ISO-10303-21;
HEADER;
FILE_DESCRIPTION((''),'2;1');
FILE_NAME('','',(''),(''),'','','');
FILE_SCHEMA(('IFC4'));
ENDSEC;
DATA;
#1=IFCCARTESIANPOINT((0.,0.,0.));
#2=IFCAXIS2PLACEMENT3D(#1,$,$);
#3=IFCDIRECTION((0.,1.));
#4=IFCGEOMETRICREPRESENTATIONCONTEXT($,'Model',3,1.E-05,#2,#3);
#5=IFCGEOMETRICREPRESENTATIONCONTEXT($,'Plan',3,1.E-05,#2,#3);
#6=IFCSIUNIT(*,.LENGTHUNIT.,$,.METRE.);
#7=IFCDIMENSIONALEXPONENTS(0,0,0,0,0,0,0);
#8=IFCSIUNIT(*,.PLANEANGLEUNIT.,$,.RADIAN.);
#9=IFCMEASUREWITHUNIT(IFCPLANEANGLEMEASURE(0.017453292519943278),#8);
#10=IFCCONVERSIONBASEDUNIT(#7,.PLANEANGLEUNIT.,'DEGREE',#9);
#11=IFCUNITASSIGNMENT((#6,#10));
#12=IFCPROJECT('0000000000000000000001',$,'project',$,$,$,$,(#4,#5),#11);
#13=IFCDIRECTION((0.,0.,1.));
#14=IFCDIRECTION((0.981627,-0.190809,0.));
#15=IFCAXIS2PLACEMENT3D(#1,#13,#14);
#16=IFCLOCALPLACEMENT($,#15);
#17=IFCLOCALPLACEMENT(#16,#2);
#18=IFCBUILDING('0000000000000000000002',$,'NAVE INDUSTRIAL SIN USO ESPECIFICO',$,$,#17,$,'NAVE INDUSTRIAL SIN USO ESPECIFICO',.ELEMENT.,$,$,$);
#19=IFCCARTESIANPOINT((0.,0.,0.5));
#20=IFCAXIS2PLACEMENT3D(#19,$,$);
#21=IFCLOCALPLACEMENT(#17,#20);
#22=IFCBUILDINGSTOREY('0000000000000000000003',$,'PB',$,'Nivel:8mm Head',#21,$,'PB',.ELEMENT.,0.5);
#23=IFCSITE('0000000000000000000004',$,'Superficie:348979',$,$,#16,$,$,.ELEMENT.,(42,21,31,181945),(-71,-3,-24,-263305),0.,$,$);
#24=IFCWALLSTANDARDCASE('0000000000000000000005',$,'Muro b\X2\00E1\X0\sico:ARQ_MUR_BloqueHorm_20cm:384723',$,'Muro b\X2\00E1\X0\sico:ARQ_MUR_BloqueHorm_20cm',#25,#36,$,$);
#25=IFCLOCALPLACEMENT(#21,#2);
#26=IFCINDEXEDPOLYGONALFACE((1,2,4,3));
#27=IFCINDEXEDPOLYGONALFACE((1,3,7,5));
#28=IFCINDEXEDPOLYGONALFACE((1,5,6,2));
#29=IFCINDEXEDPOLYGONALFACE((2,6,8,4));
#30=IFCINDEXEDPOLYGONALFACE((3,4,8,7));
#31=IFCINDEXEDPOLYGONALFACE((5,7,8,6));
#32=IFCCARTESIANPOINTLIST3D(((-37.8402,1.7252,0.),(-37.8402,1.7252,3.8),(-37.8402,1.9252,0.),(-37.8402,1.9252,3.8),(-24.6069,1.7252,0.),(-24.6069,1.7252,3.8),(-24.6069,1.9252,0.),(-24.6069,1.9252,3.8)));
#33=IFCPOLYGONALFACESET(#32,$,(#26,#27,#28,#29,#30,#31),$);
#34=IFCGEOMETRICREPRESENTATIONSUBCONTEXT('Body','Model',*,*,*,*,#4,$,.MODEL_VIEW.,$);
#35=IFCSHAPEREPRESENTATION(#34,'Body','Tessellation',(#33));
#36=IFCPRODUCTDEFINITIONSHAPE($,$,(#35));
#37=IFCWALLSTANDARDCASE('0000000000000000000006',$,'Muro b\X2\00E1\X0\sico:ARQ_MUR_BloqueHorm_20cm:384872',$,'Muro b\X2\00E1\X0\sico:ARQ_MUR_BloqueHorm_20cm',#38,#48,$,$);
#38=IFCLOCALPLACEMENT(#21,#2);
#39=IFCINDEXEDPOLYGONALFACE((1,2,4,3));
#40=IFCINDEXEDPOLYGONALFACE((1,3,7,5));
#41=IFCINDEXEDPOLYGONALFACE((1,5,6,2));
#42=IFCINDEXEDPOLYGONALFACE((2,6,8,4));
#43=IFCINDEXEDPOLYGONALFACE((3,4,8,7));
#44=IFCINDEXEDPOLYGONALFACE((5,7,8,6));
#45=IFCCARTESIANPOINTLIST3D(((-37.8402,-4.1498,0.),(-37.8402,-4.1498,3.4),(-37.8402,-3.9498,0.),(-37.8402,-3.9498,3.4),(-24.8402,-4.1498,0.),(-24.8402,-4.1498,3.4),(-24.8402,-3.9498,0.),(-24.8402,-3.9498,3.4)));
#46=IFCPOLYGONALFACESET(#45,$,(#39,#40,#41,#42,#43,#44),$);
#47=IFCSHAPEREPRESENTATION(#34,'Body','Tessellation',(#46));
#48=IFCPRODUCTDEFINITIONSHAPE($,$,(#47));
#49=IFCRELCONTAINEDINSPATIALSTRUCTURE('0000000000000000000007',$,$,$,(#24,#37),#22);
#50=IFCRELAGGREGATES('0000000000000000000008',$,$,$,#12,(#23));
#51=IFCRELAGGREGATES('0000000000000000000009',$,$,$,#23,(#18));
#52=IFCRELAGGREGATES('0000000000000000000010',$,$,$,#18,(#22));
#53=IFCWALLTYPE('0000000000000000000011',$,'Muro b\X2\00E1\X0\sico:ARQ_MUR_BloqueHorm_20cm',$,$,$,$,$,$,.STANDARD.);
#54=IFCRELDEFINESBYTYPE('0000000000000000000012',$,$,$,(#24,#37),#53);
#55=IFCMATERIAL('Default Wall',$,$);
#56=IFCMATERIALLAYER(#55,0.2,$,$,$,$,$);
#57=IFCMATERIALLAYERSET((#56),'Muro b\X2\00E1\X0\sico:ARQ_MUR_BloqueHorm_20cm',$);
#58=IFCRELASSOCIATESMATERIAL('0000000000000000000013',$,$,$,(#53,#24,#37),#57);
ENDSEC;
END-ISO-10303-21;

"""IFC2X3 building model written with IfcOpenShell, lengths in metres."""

from ifc_helpers import new_model, entity, si_unit, converted_unit, direction, frame, frame_2d, origin, place, context, subcontext, project, spatial, polyline, rectangle, extrude, clip, bounded_halfspace, material, layer, layer_set, layer_usage, type_object, element, save


model = new_model("IFC2X3")

# Units and contexts
model_context = context("Model", 3, precision=1e-05, world=origin(), true_north=direction((0.0, 1.0)))
plan_context = context("Plan", 3, precision=1e-05, world=origin(), true_north=direction((0.0, 1.0)))
body_context = subcontext(model_context, "Body", "Model", "MODEL_VIEW")
ifc_project = project(units=[si_unit("LENGTHUNIT", "METRE"), converted_unit("PLANEANGLEUNIT", "DEGREE", entity("IfcPlaneAngleMeasure", 0.017453292519943278), si_unit("PLANEANGLEUNIT", "RADIAN"), dimensions=[0, 0, 0, 0, 0, 0, 0])], contexts=[model_context, plan_context])

# Site, building, storey
site_placement = place(None, frame((0.0, 0.0, 0.0), z_axis=(0.0, 0.0, 1.0), x_axis=(0.981627, -0.190809, 0.0)))
site = spatial("IfcSite", under=ifc_project, at=site_placement, Name="Superficie:348979", CompositionType="ELEMENT", RefLatitude=(42, 21, 31, 181945), RefLongitude=(-71, -3, -24, -263305), RefElevation=0.0)
building_placement = place(site_placement, origin())
building = spatial("IfcBuilding", under=site, at=building_placement, Name="NAVE INDUSTRIAL SIN USO ESPECIFICO", LongName="NAVE INDUSTRIAL SIN USO ESPECIFICO", CompositionType="ELEMENT")
storey_placement = place(building_placement, frame((0.0, 0.0, 0.5)))
storey = spatial("IfcBuildingStorey", under=building, at=storey_placement, Name="PB", ObjectType="Nivel:8mm Head", LongName="PB", CompositionType="ELEMENT", Elevation=0.5)

# Shared definitions
ifc_material_1 = material(Name="Default Wall")
ifc_layer_1 = layer(ifc_material_1, 0.2)
ifc_layer_set_1 = layer_set([ifc_layer_1], Name="Muro básico:ARQ_MUR_BloqueHorm_20cm")
wall_type = type_object("IfcWallType", Name="Muro básico:ARQ_MUR_BloqueHorm_20cm", PredefinedType="STANDARD", material=ifc_layer_set_1)

# Walls
ifc_layer_usage_1 = layer_usage(ifc_layer_set_1, "AXIS2", "POSITIVE", -0.1)
wall_1_placement = place(storey_placement, frame((-24.6069, 1.8252, 0.0), z_axis=(0.0, 0.0, 1.0), x_axis=(-1.0, 0.0, 0.0)))
element("IfcWallStandardCase", 1, at=wall_1_placement, inside=storey, type_object=wall_type, material=ifc_layer_usage_1, Name="Muro básico:ARQ_MUR_BloqueHorm_20cm:384723", ObjectType="Muro básico:ARQ_MUR_BloqueHorm_20cm", context=body_context, shape_type="SweptSolid", body=[
    extrude(rectangle(XDim=13.2333, YDim=0.2, at=frame_2d((6.6167, 0.0), x_axis=(-1.0, 0.0))), origin(), (0.0, 0.0, 1.0), 3.8),
])
ifc_layer_usage_2 = layer_usage(ifc_layer_set_1, "AXIS2", "NEGATIVE", 0.1)
wall_2_placement = place(storey_placement, frame((-24.8402, -4.0498, 0.0), z_axis=(0.0, 0.0, 1.0), x_axis=(-1.0, 0.0, 0.0)))
element("IfcWallStandardCase", 2, at=wall_2_placement, inside=storey, type_object=wall_type, material=ifc_layer_usage_2, Name="Muro básico:ARQ_MUR_BloqueHorm_20cm:384872", ObjectType="Muro básico:ARQ_MUR_BloqueHorm_20cm", context=body_context, shape_type="Clipping", body=[
    clip(extrude(rectangle(XDim=13.0, YDim=0.2, at=frame_2d((6.5, 0.0), x_axis=(-1.0, 0.0))), origin(), (0.0, 0.0, 1.0), 3.4), bounded_halfspace(frame((0.0, -0.1, 3.4), z_axis=(0.0, 0.0, -1.0), x_axis=(-1.0, 0.0, 0.0)), True, frame((0.0, -0.1, 3.4)), polyline([(0.0, 0.0), (13.0, 0.0), (13.0, 0.2), (4.7267, 0.2), (0.0, 0.2), (0.0, 0.0)]))),
])

save(model, "model.ifc")
